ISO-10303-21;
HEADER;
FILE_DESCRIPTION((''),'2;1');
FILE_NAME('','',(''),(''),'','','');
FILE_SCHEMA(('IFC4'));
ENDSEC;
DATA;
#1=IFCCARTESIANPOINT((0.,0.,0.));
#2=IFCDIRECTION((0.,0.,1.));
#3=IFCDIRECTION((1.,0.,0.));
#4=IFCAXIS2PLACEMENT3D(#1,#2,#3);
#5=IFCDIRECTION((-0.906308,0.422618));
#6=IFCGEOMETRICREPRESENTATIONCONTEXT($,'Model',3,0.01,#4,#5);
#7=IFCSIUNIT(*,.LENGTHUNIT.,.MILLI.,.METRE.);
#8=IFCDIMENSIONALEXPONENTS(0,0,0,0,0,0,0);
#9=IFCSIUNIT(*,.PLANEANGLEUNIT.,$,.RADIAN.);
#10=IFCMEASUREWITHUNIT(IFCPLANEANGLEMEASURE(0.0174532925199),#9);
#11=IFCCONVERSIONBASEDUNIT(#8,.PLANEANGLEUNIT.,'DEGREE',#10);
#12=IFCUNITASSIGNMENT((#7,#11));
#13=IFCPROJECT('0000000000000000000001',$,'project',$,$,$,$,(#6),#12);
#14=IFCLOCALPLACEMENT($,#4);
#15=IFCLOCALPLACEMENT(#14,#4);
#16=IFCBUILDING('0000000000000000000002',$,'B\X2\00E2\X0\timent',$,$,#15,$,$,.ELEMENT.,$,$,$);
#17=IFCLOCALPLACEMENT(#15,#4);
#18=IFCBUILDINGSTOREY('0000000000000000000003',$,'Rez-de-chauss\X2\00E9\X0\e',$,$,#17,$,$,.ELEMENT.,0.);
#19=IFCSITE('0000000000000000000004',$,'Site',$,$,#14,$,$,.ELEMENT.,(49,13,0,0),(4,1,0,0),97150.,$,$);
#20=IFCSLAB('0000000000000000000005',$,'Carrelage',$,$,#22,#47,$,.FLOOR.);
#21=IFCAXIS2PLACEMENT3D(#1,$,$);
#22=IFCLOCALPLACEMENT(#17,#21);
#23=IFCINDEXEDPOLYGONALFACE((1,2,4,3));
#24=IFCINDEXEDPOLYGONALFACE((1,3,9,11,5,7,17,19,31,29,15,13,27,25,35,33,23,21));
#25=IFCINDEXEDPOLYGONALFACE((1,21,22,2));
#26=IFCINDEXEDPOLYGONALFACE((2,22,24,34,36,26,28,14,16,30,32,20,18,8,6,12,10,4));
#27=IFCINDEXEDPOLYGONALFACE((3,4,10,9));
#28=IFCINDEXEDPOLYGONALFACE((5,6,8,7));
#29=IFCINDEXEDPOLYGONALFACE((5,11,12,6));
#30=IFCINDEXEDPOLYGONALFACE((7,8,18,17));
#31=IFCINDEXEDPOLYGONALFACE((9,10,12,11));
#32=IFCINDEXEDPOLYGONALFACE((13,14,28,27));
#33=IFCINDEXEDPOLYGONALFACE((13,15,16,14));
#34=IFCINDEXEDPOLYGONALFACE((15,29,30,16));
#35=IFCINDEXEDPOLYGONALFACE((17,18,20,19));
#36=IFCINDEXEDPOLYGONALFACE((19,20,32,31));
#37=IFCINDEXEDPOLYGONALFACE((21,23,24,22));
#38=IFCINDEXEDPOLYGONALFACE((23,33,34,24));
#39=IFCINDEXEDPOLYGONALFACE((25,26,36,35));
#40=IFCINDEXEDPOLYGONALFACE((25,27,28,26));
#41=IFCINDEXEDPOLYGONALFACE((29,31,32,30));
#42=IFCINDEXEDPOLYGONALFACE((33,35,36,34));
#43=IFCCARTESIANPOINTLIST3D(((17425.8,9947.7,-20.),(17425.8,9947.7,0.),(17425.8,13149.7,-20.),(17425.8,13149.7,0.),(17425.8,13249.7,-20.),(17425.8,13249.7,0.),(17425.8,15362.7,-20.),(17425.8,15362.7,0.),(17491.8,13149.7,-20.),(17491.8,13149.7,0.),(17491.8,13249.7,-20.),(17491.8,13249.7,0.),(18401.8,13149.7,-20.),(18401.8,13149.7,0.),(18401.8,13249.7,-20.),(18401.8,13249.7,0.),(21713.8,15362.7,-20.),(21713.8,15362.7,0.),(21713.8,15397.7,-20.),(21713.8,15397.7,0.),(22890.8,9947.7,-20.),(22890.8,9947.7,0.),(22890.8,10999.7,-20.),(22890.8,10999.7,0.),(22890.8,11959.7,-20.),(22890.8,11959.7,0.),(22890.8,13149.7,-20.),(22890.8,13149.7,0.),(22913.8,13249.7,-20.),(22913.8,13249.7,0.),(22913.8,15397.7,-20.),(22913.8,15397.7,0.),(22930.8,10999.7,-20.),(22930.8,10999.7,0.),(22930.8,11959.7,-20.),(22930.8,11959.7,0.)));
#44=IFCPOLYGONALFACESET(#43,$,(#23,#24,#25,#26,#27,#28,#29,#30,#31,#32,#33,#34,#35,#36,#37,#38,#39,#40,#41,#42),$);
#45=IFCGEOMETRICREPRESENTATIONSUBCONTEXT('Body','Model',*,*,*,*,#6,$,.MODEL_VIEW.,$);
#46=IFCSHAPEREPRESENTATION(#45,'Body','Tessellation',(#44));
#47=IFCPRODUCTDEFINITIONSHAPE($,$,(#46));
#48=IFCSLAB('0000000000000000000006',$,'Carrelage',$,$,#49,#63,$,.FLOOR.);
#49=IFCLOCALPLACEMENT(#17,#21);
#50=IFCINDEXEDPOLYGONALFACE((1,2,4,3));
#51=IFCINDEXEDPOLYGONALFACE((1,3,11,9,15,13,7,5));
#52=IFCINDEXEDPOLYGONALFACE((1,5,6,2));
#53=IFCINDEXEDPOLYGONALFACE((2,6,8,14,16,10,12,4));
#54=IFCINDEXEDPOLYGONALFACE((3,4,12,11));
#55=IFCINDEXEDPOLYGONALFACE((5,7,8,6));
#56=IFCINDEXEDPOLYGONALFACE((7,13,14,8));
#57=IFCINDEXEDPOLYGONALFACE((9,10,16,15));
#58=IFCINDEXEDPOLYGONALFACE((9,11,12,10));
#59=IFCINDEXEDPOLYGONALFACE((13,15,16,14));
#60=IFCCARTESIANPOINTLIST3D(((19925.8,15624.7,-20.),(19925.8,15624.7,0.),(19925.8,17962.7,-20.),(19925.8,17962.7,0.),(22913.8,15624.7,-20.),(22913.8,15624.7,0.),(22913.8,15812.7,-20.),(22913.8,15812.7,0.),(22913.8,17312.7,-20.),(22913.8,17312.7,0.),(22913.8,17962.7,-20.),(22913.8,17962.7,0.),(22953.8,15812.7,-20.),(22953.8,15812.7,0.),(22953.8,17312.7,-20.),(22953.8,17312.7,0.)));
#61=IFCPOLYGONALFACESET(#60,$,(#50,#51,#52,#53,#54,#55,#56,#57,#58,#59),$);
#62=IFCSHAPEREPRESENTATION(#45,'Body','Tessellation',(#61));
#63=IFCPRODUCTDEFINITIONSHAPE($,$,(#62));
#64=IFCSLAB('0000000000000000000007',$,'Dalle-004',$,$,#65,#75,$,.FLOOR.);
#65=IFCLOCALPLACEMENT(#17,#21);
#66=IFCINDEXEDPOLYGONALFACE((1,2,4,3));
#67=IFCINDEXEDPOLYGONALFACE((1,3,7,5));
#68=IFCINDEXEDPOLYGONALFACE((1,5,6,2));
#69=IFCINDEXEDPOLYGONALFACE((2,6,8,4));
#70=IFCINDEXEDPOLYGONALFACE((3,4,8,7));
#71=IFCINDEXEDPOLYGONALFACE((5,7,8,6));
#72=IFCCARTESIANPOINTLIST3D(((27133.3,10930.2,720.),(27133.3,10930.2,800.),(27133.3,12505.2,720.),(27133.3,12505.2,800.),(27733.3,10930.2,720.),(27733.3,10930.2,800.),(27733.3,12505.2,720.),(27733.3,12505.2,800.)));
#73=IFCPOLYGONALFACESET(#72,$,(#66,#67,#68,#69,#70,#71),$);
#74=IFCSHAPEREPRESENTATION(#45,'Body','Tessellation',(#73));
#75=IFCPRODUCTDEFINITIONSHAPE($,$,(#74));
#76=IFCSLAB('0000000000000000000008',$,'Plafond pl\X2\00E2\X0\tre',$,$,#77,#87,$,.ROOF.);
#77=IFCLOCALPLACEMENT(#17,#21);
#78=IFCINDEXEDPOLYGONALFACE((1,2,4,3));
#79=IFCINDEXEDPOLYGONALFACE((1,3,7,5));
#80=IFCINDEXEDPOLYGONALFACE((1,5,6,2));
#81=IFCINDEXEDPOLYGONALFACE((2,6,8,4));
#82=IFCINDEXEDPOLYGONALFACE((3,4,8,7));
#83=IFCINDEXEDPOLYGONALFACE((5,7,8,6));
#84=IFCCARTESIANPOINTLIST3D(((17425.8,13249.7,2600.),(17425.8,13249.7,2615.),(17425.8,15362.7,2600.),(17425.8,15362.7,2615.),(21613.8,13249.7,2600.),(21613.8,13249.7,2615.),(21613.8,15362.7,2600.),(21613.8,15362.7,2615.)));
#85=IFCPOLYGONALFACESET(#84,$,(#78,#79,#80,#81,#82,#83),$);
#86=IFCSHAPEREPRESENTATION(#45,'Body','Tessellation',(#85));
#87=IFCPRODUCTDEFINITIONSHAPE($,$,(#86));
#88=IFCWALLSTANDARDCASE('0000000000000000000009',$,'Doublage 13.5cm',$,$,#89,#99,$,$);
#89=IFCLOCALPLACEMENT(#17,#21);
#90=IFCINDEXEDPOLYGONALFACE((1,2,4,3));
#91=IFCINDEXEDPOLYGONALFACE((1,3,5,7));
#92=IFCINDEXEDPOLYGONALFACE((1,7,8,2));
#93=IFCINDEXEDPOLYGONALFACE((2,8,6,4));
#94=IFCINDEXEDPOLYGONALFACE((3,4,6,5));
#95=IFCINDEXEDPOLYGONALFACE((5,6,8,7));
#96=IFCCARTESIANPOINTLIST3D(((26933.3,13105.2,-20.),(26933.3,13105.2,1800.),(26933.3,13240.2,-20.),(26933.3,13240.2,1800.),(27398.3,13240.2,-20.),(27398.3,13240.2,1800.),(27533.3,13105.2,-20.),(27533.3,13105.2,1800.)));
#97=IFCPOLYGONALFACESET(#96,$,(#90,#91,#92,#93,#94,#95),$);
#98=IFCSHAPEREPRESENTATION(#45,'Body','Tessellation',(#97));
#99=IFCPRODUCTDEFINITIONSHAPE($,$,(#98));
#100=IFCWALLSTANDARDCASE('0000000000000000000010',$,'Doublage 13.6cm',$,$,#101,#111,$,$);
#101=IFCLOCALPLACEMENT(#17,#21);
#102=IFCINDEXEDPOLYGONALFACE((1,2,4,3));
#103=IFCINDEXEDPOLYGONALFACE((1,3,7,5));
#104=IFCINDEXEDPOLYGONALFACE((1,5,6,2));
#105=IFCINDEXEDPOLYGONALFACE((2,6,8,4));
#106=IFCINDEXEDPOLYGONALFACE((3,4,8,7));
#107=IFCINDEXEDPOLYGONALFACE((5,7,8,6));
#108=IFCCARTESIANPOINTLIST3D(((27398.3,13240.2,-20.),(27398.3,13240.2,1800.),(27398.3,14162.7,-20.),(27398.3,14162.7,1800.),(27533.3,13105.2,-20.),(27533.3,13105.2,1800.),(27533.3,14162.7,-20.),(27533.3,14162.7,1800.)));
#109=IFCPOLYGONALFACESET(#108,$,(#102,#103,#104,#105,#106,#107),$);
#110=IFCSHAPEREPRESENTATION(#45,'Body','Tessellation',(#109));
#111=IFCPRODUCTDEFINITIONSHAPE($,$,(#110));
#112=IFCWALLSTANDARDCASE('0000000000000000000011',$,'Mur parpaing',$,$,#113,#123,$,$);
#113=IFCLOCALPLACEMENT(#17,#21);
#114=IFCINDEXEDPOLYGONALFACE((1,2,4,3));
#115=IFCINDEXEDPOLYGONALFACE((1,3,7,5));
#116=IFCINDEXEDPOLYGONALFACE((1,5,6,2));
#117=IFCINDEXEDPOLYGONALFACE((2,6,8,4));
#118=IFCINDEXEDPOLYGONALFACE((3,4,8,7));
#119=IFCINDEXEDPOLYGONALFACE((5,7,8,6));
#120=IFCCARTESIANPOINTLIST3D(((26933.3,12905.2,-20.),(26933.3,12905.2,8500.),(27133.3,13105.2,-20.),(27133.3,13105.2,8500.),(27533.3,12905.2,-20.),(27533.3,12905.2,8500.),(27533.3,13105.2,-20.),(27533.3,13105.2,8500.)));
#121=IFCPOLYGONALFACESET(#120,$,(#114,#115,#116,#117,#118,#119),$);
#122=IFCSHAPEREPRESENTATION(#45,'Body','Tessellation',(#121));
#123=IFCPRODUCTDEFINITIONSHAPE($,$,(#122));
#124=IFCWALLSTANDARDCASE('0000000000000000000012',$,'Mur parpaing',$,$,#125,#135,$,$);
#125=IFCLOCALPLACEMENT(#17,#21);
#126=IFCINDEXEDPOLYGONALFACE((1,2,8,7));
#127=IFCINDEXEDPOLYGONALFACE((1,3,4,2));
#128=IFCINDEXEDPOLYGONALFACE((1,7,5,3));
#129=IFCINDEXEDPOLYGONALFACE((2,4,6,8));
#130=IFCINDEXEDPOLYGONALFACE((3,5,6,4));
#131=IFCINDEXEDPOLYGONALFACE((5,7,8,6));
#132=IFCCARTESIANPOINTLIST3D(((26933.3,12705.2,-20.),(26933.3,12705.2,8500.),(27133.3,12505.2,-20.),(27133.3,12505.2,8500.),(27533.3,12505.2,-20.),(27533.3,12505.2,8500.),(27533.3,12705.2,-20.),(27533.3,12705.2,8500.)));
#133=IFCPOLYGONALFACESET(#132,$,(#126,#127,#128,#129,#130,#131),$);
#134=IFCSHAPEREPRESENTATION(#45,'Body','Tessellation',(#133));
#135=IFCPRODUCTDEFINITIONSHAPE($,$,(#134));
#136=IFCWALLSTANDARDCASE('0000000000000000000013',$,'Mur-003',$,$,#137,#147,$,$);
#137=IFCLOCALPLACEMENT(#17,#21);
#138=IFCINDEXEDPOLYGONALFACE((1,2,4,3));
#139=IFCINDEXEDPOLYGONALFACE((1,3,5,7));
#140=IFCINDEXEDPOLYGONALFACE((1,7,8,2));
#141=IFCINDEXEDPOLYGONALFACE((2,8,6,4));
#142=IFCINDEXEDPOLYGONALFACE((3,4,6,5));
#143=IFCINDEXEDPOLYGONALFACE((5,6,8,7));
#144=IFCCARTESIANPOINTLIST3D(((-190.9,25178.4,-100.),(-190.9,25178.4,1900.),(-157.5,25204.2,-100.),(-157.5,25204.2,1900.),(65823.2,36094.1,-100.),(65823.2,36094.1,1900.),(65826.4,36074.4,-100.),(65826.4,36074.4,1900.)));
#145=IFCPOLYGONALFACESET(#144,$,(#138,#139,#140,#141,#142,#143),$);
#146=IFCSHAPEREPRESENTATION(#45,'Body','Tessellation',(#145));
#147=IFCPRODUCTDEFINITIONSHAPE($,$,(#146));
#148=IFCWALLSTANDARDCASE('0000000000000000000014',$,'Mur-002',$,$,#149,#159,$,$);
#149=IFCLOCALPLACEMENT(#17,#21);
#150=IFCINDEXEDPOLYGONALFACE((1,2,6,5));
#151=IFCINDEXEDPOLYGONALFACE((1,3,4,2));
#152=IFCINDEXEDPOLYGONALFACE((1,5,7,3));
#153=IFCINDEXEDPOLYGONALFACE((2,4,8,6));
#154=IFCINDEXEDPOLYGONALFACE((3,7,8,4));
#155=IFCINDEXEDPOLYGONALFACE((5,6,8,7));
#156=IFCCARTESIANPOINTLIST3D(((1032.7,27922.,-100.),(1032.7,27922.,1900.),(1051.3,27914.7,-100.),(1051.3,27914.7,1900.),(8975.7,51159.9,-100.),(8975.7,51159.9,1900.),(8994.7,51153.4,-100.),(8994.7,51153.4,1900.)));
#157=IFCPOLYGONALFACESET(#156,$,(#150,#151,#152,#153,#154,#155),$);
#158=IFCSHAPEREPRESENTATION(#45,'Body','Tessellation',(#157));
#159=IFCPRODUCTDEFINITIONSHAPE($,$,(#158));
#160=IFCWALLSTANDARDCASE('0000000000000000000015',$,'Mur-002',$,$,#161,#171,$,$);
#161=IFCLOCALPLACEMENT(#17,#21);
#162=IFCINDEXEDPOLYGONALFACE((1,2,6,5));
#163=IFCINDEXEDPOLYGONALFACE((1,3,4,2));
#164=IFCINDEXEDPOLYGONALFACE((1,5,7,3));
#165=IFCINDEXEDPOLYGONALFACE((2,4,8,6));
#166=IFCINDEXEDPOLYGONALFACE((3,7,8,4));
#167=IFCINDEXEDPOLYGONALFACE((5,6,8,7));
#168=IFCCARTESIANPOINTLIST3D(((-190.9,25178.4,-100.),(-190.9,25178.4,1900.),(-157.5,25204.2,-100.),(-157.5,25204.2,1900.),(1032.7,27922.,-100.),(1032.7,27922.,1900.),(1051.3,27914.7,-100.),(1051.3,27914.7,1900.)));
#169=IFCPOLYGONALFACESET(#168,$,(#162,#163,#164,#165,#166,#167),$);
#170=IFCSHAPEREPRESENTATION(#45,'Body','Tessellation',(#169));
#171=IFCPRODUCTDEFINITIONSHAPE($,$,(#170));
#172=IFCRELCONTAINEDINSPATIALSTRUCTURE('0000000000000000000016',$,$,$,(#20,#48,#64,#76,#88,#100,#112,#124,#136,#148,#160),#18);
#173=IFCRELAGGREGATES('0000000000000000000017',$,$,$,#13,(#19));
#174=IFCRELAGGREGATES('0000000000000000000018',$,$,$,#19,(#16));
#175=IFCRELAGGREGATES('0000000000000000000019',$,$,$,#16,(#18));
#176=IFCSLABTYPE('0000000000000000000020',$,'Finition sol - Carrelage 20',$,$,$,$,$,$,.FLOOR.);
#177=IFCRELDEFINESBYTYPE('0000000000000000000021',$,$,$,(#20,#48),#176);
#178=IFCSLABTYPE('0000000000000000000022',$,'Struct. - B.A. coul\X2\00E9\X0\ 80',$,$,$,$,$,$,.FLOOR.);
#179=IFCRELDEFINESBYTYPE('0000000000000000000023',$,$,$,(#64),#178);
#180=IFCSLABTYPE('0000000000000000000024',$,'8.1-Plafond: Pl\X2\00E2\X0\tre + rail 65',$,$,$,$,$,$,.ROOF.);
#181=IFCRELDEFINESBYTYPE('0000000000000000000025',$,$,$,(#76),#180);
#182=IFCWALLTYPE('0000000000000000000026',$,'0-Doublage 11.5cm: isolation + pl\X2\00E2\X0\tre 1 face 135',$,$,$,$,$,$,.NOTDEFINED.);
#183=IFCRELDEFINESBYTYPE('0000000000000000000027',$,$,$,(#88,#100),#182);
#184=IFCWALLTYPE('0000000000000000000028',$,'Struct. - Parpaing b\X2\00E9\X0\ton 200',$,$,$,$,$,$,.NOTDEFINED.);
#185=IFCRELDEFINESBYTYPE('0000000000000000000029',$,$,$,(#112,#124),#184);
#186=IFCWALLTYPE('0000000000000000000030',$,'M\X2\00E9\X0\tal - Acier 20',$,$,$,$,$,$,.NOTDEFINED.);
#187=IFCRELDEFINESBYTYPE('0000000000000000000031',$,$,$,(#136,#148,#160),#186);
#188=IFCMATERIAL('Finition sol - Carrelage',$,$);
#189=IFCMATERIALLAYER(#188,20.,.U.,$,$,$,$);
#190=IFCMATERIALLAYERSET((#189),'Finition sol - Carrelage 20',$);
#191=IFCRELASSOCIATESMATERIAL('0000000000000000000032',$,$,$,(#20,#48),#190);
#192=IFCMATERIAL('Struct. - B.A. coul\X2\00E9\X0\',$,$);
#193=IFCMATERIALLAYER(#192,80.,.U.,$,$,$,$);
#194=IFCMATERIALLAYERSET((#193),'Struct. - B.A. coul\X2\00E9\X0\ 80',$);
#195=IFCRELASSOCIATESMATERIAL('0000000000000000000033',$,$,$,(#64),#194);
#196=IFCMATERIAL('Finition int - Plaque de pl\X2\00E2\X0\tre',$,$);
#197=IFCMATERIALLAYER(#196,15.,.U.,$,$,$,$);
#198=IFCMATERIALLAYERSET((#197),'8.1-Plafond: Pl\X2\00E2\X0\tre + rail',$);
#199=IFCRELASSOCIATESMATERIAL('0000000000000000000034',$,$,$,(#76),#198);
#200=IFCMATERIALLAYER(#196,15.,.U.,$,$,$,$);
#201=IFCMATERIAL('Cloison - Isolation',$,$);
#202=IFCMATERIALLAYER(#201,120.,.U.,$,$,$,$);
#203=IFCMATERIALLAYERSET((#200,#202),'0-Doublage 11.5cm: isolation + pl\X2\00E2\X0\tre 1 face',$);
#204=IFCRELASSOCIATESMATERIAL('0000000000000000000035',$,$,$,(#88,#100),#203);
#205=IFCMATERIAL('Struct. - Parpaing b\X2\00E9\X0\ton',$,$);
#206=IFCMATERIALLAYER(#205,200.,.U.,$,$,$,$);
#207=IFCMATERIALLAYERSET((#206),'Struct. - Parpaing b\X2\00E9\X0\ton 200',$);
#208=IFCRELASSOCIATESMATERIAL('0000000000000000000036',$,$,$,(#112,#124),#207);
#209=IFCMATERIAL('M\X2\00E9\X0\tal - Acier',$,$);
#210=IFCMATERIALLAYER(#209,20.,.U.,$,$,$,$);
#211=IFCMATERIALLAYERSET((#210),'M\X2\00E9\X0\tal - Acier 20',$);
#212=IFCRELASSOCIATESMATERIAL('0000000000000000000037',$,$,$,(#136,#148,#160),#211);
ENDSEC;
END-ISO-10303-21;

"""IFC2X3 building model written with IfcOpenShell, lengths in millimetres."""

from ifc_helpers import new_model, entity, si_unit, converted_unit, direction, frame, origin_with_axes, place, context, subcontext, project, spatial, polyline, outline, extrude, material, layer, layer_set, layer_usage, type_object, element, save


model = new_model("IFC2X3")

# Units and contexts
model_context = context("Model", 3, precision=0.01, world=origin_with_axes(), true_north=direction((-0.906308, 0.422618)))
body_context = subcontext(model_context, "Body", "Model", "MODEL_VIEW")
ifc_project = project(units=[si_unit("LENGTHUNIT", "METRE", prefix="MILLI"), converted_unit("PLANEANGLEUNIT", "DEGREE", entity("IfcPlaneAngleMeasure", 0.0174532925199), si_unit("PLANEANGLEUNIT", "RADIAN"), dimensions=[0, 0, 0, 0, 0, 0, 0])], contexts=[model_context])

# Site, building, storey
site_placement = place(None, origin_with_axes())
site = spatial("IfcSite", under=ifc_project, at=site_placement, Name="Site", CompositionType="ELEMENT", RefLatitude=(49, 13, 0, 0), RefLongitude=(4, 1, 0, 0), RefElevation=97150.0)
building_placement = place(site_placement, origin_with_axes())
building = spatial("IfcBuilding", under=site, at=building_placement, Name="Bâtiment", CompositionType="ELEMENT")
storey_placement = place(building_placement, origin_with_axes())
storey = spatial("IfcBuildingStorey", under=building, at=storey_placement, Name="Rez-de-chaussée", CompositionType="ELEMENT", Elevation=0.0)

# Slabs
ifc_material_1 = material(Name="Struct. - B.A. coulé")
ifc_material_2 = material(Name="Finition sol - Carrelage")
ifc_layer_1 = layer(ifc_material_2, 20.0, ventilated="UNKNOWN")
ifc_layer_set_1 = layer_set([ifc_layer_1], Name="Finition sol - Carrelage 20")
ifc_layer_usage_1 = layer_usage(ifc_layer_set_1, "AXIS3", "NEGATIVE", 20.0)
slab_type_1 = type_object("IfcSlabType", Name="Finition sol - Carrelage 20", PredefinedType="FLOOR")
slab_1_placement = place(storey_placement, frame((17425.8, 13149.7, 0.0), z_axis=(0.0, 0.0, 1.0), x_axis=(1.0, 0.0, 0.0)))
element("IfcSlab", 1, at=slab_1_placement, inside=storey, type_object=slab_type_1, material=ifc_layer_usage_1, Name="Carrelage", PredefinedType="FLOOR", context=body_context, shape_type="SweptSolid", body=[
    extrude(outline(polyline([(0.0, 0.0), (0.0, -3202.0), (5465.0, -3202.0), (5465.0, -2150.0), (5505.0, -2150.0), (5505.0, -1190.0), (5465.0, -1190.0), (5465.0, 0.0), (976.0, 0.0), (976.0, 100.0), (5488.0, 100.0), (5488.0, 2248.0), (4288.0, 2248.0), (4288.0, 2213.0), (0.0, 2213.0), (0.0, 100.0), (66.0, 100.0), (66.0, 0.0), (0.0, 0.0)])), frame((0.0, 0.0, -20.0), z_axis=(0.0, 0.0, 1.0), x_axis=(1.0, 0.0, 0.0)), (0.0, 0.0, 1.0), 20.0),
])
ifc_layer_usage_2 = layer_usage(ifc_layer_set_1, "AXIS3", "NEGATIVE", 20.0)
slab_2_placement = place(storey_placement, frame((19925.8, 17962.7, 0.0), z_axis=(0.0, 0.0, 1.0), x_axis=(1.0, 0.0, 0.0)))
element("IfcSlab", 2, at=slab_2_placement, inside=storey, type_object=slab_type_1, material=ifc_layer_usage_2, Name="Carrelage", PredefinedType="FLOOR", context=body_context, shape_type="SweptSolid", body=[
    extrude(outline(polyline([(0.0, 0.0), (0.0, -2338.0), (2988.0, -2338.0), (2988.0, -2150.0), (3028.0, -2150.0), (3028.0, -650.0), (2988.0, -650.0), (2988.0, 0.0), (0.0, 0.0)])), frame((0.0, 0.0, -20.0), z_axis=(0.0, 0.0, 1.0), x_axis=(1.0, 0.0, 0.0)), (0.0, 0.0, 1.0), 20.0),
])
ifc_layer_2 = layer(ifc_material_1, 80.0, ventilated="UNKNOWN")
ifc_layer_set_2 = layer_set([ifc_layer_2], Name="Struct. - B.A. coulé 80")
ifc_layer_usage_3 = layer_usage(ifc_layer_set_2, "AXIS3", "NEGATIVE", 80.0)
slab_type_2 = type_object("IfcSlabType", Name="Struct. - B.A. coulé 80", PredefinedType="FLOOR")
slab_3_placement = place(storey_placement, frame((27133.3, 10930.2, 800.0), z_axis=(0.0, 0.0, 1.0), x_axis=(1.0, 0.0, 0.0)))
element("IfcSlab", 3, at=slab_3_placement, inside=storey, type_object=slab_type_2, material=ifc_layer_usage_3, Name="Dalle-004", PredefinedType="FLOOR", context=body_context, shape_type="SweptSolid", body=[
    extrude(outline(polyline([(0.0, 0.0), (600.0, 0.0), (600.0, 1575.0), (0.0, 1575.0), (0.0, 0.0)])), frame((0.0, 0.0, -80.0), z_axis=(0.0, 0.0, 1.0), x_axis=(1.0, 0.0, 0.0)), (0.0, 0.0, 1.0), 80.0),
])
ifc_material_3 = material(Name="Finition int - Plaque de plâtre")
ifc_layer_3 = layer(ifc_material_3, 15.0, ventilated="UNKNOWN")
ifc_layer_set_3 = layer_set([ifc_layer_3], Name="8.1-Plafond: Plâtre + rail")
ifc_layer_usage_4 = layer_usage(ifc_layer_set_3, "AXIS3", "NEGATIVE", 15.0)
slab_type_3 = type_object("IfcSlabType", Name="8.1-Plafond: Plâtre + rail 65", PredefinedType="ROOF")
slab_4_placement = place(storey_placement, frame((17425.8, 15362.7, 2600.0), z_axis=(0.0, 0.0, 1.0), x_axis=(1.0, 0.0, 0.0)))
element("IfcSlab", 4, at=slab_4_placement, inside=storey, type_object=slab_type_3, material=ifc_layer_usage_4, Name="Plafond plâtre", PredefinedType="ROOF", context=body_context, shape_type="SweptSolid", body=[
    extrude(outline(polyline([(4188.0, 0.0), (0.0, 0.0), (0.0, -2113.0), (4188.0, -2113.0), (4188.0, 0.0)])), origin_with_axes(), (0.0, 0.0, 1.0), 15.0),
])

# Walls
ifc_layer_4 = layer(ifc_material_3, 15.0, ventilated="UNKNOWN")
ifc_material_4 = material(Name="Cloison - Isolation")
ifc_layer_5 = layer(ifc_material_4, 120.0, ventilated="UNKNOWN")
ifc_layer_set_4 = layer_set([ifc_layer_4, ifc_layer_5], Name="0-Doublage 11.5cm: isolation + plâtre 1 face")
ifc_layer_usage_5 = layer_usage(ifc_layer_set_4, "AXIS2", "NEGATIVE", 0.0)
wall_type_1 = type_object("IfcWallType", Name="0-Doublage 11.5cm: isolation + plâtre 1 face 135", PredefinedType="NOTDEFINED")
wall_1_placement = place(storey_placement, frame((26798.3, 13240.2, -20.0), z_axis=(0.0, 0.0, 1.0), x_axis=(1.0, 0.0, 0.0)))
element("IfcWallStandardCase", 5, at=wall_1_placement, inside=storey, type_object=wall_type_1, material=ifc_layer_usage_5, Name="Doublage 13.5cm", context=body_context, shape_type="SweptSolid", body=[
    extrude(outline(polyline([(135.0, -135.0), (735.0, -135.0), (600.0, 0.0), (135.0, 0.0), (135.0, -135.0)])), origin_with_axes(), (0.0, 0.0, 1.0), 1820.0),
])
ifc_layer_usage_6 = layer_usage(ifc_layer_set_4, "AXIS2", "NEGATIVE", 0.0)
wall_2_placement = place(storey_placement, frame((27398.3, 13240.2, -20.0), z_axis=(0.0, 0.0, 1.0), x_axis=(0.0, 1.0, 0.0)))
element("IfcWallStandardCase", 6, at=wall_2_placement, inside=storey, type_object=wall_type_1, material=ifc_layer_usage_6, Name="Doublage 13.6cm", context=body_context, shape_type="SweptSolid", body=[
    extrude(outline(polyline([(-135.0, -135.0), (922.5, -135.0), (922.5, 0.0), (0.0, 0.0), (-135.0, -135.0)])), origin_with_axes(), (0.0, 0.0, 1.0), 1820.0),
])
ifc_material_5 = material(Name="Struct. - Parpaing béton")
ifc_layer_6 = layer(ifc_material_5, 200.0, ventilated="UNKNOWN")
ifc_layer_set_5 = layer_set([ifc_layer_6], Name="Struct. - Parpaing béton 200")
ifc_layer_usage_7 = layer_usage(ifc_layer_set_5, "AXIS2", "POSITIVE", -100.0)
wall_type_2 = type_object("IfcWallType", Name="Struct. - Parpaing béton 200", PredefinedType="NOTDEFINED")
wall_3_placement = place(storey_placement, frame((27033.3, 13005.2, -20.0), z_axis=(0.0, 0.0, 1.0), x_axis=(1.0, 0.0, 0.0)))
element("IfcWallStandardCase", 7, at=wall_3_placement, inside=storey, type_object=wall_type_2, material=ifc_layer_usage_7, Name="Mur parpaing", context=body_context, shape_type="SweptSolid", body=[
    extrude(outline(polyline([(-100.0, -100.0), (500.0, -100.0), (500.0, 100.0), (100.0, 100.0), (-100.0, -100.0)])), origin_with_axes(), (0.0, 0.0, 1.0), 8520.0),
])
ifc_layer_usage_8 = layer_usage(ifc_layer_set_5, "AXIS2", "POSITIVE", 0.0)
wall_4_placement = place(storey_placement, frame((27033.3, 12505.2, -20.0), z_axis=(0.0, 0.0, 1.0), x_axis=(1.0, 0.0, 0.0)))
element("IfcWallStandardCase", 8, at=wall_4_placement, inside=storey, type_object=wall_type_2, material=ifc_layer_usage_8, Name="Mur parpaing", context=body_context, shape_type="SweptSolid", body=[
    extrude(outline(polyline([(100.0, 0.0), (500.0, 0.0), (500.0, 200.0), (-100.0, 200.0), (100.0, 0.0)])), origin_with_axes(), (0.0, 0.0, 1.0), 8520.0),
])
ifc_material_6 = material(Name="Métal - Acier")
ifc_layer_7 = layer(ifc_material_6, 20.0, ventilated="UNKNOWN")
ifc_layer_set_6 = layer_set([ifc_layer_7], Name="Métal - Acier 20")
ifc_layer_usage_9 = layer_usage(ifc_layer_set_6, "AXIS2", "POSITIVE", -10.0)
wall_type_3 = type_object("IfcWallType", Name="Métal - Acier 20", PredefinedType="NOTDEFINED")
wall_5_placement = place(storey_placement, frame((-174.2, 25191.3, -100.0), z_axis=(0.0, 0.0, 1.0), x_axis=(0.986652, 0.162844, 0.0)))
element("IfcWallStandardCase", 9, at=wall_5_placement, inside=storey, type_object=wall_type_3, material=ifc_layer_usage_9, Name="Mur-003", context=body_context, shape_type="SweptSolid", body=[
    extrude(outline(polyline([(-18.6, -10.0), (66891.9, -10.0), (66891.9, 10.0), (18.6, 10.0), (-18.6, -10.0)])), origin_with_axes(), (0.0, 0.0, 1.0), 2000.0),
])
ifc_layer_usage_10 = layer_usage(ifc_layer_set_6, "AXIS2", "POSITIVE", -10.0)
wall_6_placement = place(storey_placement, frame((8985.2, 51156.6, -100.0), z_axis=(0.0, 0.0, 1.0), x_axis=(-0.32344, -0.946249, 0.0)))
element("IfcWallStandardCase", 10, at=wall_6_placement, inside=storey, type_object=wall_type_3, material=ifc_layer_usage_10, Name="Mur-002", context=body_context, shape_type="SweptSolid", body=[
    extrude(outline(polyline([(0.0, -10.0), (24557.9, -10.0), (24558.8, 10.0), (0.0, 10.0), (0.0, -10.0)])), origin_with_axes(), (0.0, 0.0, 1.0), 2000.0),
])
ifc_layer_usage_11 = layer_usage(ifc_layer_set_6, "AXIS2", "POSITIVE", -10.0)
wall_7_placement = place(storey_placement, frame((1042.0, 27918.3, -100.0), z_axis=(0.0, 0.0, 1.0), x_axis=(-0.407311, -0.91329, 0.0)))
element("IfcWallStandardCase", 11, at=wall_7_placement, inside=storey, type_object=wall_type_3, material=ifc_layer_usage_11, Name="Mur-002", context=body_context, shape_type="SweptSolid", body=[
    extrude(outline(polyline([(0.5, -10.0), (3004.5, -10.0), (2967.3, 10.0), (-0.5, 10.0), (0.5, -10.0)])), origin_with_axes(), (0.0, 0.0, 1.0), 2000.0),
])

save(model, "model.ifc")
